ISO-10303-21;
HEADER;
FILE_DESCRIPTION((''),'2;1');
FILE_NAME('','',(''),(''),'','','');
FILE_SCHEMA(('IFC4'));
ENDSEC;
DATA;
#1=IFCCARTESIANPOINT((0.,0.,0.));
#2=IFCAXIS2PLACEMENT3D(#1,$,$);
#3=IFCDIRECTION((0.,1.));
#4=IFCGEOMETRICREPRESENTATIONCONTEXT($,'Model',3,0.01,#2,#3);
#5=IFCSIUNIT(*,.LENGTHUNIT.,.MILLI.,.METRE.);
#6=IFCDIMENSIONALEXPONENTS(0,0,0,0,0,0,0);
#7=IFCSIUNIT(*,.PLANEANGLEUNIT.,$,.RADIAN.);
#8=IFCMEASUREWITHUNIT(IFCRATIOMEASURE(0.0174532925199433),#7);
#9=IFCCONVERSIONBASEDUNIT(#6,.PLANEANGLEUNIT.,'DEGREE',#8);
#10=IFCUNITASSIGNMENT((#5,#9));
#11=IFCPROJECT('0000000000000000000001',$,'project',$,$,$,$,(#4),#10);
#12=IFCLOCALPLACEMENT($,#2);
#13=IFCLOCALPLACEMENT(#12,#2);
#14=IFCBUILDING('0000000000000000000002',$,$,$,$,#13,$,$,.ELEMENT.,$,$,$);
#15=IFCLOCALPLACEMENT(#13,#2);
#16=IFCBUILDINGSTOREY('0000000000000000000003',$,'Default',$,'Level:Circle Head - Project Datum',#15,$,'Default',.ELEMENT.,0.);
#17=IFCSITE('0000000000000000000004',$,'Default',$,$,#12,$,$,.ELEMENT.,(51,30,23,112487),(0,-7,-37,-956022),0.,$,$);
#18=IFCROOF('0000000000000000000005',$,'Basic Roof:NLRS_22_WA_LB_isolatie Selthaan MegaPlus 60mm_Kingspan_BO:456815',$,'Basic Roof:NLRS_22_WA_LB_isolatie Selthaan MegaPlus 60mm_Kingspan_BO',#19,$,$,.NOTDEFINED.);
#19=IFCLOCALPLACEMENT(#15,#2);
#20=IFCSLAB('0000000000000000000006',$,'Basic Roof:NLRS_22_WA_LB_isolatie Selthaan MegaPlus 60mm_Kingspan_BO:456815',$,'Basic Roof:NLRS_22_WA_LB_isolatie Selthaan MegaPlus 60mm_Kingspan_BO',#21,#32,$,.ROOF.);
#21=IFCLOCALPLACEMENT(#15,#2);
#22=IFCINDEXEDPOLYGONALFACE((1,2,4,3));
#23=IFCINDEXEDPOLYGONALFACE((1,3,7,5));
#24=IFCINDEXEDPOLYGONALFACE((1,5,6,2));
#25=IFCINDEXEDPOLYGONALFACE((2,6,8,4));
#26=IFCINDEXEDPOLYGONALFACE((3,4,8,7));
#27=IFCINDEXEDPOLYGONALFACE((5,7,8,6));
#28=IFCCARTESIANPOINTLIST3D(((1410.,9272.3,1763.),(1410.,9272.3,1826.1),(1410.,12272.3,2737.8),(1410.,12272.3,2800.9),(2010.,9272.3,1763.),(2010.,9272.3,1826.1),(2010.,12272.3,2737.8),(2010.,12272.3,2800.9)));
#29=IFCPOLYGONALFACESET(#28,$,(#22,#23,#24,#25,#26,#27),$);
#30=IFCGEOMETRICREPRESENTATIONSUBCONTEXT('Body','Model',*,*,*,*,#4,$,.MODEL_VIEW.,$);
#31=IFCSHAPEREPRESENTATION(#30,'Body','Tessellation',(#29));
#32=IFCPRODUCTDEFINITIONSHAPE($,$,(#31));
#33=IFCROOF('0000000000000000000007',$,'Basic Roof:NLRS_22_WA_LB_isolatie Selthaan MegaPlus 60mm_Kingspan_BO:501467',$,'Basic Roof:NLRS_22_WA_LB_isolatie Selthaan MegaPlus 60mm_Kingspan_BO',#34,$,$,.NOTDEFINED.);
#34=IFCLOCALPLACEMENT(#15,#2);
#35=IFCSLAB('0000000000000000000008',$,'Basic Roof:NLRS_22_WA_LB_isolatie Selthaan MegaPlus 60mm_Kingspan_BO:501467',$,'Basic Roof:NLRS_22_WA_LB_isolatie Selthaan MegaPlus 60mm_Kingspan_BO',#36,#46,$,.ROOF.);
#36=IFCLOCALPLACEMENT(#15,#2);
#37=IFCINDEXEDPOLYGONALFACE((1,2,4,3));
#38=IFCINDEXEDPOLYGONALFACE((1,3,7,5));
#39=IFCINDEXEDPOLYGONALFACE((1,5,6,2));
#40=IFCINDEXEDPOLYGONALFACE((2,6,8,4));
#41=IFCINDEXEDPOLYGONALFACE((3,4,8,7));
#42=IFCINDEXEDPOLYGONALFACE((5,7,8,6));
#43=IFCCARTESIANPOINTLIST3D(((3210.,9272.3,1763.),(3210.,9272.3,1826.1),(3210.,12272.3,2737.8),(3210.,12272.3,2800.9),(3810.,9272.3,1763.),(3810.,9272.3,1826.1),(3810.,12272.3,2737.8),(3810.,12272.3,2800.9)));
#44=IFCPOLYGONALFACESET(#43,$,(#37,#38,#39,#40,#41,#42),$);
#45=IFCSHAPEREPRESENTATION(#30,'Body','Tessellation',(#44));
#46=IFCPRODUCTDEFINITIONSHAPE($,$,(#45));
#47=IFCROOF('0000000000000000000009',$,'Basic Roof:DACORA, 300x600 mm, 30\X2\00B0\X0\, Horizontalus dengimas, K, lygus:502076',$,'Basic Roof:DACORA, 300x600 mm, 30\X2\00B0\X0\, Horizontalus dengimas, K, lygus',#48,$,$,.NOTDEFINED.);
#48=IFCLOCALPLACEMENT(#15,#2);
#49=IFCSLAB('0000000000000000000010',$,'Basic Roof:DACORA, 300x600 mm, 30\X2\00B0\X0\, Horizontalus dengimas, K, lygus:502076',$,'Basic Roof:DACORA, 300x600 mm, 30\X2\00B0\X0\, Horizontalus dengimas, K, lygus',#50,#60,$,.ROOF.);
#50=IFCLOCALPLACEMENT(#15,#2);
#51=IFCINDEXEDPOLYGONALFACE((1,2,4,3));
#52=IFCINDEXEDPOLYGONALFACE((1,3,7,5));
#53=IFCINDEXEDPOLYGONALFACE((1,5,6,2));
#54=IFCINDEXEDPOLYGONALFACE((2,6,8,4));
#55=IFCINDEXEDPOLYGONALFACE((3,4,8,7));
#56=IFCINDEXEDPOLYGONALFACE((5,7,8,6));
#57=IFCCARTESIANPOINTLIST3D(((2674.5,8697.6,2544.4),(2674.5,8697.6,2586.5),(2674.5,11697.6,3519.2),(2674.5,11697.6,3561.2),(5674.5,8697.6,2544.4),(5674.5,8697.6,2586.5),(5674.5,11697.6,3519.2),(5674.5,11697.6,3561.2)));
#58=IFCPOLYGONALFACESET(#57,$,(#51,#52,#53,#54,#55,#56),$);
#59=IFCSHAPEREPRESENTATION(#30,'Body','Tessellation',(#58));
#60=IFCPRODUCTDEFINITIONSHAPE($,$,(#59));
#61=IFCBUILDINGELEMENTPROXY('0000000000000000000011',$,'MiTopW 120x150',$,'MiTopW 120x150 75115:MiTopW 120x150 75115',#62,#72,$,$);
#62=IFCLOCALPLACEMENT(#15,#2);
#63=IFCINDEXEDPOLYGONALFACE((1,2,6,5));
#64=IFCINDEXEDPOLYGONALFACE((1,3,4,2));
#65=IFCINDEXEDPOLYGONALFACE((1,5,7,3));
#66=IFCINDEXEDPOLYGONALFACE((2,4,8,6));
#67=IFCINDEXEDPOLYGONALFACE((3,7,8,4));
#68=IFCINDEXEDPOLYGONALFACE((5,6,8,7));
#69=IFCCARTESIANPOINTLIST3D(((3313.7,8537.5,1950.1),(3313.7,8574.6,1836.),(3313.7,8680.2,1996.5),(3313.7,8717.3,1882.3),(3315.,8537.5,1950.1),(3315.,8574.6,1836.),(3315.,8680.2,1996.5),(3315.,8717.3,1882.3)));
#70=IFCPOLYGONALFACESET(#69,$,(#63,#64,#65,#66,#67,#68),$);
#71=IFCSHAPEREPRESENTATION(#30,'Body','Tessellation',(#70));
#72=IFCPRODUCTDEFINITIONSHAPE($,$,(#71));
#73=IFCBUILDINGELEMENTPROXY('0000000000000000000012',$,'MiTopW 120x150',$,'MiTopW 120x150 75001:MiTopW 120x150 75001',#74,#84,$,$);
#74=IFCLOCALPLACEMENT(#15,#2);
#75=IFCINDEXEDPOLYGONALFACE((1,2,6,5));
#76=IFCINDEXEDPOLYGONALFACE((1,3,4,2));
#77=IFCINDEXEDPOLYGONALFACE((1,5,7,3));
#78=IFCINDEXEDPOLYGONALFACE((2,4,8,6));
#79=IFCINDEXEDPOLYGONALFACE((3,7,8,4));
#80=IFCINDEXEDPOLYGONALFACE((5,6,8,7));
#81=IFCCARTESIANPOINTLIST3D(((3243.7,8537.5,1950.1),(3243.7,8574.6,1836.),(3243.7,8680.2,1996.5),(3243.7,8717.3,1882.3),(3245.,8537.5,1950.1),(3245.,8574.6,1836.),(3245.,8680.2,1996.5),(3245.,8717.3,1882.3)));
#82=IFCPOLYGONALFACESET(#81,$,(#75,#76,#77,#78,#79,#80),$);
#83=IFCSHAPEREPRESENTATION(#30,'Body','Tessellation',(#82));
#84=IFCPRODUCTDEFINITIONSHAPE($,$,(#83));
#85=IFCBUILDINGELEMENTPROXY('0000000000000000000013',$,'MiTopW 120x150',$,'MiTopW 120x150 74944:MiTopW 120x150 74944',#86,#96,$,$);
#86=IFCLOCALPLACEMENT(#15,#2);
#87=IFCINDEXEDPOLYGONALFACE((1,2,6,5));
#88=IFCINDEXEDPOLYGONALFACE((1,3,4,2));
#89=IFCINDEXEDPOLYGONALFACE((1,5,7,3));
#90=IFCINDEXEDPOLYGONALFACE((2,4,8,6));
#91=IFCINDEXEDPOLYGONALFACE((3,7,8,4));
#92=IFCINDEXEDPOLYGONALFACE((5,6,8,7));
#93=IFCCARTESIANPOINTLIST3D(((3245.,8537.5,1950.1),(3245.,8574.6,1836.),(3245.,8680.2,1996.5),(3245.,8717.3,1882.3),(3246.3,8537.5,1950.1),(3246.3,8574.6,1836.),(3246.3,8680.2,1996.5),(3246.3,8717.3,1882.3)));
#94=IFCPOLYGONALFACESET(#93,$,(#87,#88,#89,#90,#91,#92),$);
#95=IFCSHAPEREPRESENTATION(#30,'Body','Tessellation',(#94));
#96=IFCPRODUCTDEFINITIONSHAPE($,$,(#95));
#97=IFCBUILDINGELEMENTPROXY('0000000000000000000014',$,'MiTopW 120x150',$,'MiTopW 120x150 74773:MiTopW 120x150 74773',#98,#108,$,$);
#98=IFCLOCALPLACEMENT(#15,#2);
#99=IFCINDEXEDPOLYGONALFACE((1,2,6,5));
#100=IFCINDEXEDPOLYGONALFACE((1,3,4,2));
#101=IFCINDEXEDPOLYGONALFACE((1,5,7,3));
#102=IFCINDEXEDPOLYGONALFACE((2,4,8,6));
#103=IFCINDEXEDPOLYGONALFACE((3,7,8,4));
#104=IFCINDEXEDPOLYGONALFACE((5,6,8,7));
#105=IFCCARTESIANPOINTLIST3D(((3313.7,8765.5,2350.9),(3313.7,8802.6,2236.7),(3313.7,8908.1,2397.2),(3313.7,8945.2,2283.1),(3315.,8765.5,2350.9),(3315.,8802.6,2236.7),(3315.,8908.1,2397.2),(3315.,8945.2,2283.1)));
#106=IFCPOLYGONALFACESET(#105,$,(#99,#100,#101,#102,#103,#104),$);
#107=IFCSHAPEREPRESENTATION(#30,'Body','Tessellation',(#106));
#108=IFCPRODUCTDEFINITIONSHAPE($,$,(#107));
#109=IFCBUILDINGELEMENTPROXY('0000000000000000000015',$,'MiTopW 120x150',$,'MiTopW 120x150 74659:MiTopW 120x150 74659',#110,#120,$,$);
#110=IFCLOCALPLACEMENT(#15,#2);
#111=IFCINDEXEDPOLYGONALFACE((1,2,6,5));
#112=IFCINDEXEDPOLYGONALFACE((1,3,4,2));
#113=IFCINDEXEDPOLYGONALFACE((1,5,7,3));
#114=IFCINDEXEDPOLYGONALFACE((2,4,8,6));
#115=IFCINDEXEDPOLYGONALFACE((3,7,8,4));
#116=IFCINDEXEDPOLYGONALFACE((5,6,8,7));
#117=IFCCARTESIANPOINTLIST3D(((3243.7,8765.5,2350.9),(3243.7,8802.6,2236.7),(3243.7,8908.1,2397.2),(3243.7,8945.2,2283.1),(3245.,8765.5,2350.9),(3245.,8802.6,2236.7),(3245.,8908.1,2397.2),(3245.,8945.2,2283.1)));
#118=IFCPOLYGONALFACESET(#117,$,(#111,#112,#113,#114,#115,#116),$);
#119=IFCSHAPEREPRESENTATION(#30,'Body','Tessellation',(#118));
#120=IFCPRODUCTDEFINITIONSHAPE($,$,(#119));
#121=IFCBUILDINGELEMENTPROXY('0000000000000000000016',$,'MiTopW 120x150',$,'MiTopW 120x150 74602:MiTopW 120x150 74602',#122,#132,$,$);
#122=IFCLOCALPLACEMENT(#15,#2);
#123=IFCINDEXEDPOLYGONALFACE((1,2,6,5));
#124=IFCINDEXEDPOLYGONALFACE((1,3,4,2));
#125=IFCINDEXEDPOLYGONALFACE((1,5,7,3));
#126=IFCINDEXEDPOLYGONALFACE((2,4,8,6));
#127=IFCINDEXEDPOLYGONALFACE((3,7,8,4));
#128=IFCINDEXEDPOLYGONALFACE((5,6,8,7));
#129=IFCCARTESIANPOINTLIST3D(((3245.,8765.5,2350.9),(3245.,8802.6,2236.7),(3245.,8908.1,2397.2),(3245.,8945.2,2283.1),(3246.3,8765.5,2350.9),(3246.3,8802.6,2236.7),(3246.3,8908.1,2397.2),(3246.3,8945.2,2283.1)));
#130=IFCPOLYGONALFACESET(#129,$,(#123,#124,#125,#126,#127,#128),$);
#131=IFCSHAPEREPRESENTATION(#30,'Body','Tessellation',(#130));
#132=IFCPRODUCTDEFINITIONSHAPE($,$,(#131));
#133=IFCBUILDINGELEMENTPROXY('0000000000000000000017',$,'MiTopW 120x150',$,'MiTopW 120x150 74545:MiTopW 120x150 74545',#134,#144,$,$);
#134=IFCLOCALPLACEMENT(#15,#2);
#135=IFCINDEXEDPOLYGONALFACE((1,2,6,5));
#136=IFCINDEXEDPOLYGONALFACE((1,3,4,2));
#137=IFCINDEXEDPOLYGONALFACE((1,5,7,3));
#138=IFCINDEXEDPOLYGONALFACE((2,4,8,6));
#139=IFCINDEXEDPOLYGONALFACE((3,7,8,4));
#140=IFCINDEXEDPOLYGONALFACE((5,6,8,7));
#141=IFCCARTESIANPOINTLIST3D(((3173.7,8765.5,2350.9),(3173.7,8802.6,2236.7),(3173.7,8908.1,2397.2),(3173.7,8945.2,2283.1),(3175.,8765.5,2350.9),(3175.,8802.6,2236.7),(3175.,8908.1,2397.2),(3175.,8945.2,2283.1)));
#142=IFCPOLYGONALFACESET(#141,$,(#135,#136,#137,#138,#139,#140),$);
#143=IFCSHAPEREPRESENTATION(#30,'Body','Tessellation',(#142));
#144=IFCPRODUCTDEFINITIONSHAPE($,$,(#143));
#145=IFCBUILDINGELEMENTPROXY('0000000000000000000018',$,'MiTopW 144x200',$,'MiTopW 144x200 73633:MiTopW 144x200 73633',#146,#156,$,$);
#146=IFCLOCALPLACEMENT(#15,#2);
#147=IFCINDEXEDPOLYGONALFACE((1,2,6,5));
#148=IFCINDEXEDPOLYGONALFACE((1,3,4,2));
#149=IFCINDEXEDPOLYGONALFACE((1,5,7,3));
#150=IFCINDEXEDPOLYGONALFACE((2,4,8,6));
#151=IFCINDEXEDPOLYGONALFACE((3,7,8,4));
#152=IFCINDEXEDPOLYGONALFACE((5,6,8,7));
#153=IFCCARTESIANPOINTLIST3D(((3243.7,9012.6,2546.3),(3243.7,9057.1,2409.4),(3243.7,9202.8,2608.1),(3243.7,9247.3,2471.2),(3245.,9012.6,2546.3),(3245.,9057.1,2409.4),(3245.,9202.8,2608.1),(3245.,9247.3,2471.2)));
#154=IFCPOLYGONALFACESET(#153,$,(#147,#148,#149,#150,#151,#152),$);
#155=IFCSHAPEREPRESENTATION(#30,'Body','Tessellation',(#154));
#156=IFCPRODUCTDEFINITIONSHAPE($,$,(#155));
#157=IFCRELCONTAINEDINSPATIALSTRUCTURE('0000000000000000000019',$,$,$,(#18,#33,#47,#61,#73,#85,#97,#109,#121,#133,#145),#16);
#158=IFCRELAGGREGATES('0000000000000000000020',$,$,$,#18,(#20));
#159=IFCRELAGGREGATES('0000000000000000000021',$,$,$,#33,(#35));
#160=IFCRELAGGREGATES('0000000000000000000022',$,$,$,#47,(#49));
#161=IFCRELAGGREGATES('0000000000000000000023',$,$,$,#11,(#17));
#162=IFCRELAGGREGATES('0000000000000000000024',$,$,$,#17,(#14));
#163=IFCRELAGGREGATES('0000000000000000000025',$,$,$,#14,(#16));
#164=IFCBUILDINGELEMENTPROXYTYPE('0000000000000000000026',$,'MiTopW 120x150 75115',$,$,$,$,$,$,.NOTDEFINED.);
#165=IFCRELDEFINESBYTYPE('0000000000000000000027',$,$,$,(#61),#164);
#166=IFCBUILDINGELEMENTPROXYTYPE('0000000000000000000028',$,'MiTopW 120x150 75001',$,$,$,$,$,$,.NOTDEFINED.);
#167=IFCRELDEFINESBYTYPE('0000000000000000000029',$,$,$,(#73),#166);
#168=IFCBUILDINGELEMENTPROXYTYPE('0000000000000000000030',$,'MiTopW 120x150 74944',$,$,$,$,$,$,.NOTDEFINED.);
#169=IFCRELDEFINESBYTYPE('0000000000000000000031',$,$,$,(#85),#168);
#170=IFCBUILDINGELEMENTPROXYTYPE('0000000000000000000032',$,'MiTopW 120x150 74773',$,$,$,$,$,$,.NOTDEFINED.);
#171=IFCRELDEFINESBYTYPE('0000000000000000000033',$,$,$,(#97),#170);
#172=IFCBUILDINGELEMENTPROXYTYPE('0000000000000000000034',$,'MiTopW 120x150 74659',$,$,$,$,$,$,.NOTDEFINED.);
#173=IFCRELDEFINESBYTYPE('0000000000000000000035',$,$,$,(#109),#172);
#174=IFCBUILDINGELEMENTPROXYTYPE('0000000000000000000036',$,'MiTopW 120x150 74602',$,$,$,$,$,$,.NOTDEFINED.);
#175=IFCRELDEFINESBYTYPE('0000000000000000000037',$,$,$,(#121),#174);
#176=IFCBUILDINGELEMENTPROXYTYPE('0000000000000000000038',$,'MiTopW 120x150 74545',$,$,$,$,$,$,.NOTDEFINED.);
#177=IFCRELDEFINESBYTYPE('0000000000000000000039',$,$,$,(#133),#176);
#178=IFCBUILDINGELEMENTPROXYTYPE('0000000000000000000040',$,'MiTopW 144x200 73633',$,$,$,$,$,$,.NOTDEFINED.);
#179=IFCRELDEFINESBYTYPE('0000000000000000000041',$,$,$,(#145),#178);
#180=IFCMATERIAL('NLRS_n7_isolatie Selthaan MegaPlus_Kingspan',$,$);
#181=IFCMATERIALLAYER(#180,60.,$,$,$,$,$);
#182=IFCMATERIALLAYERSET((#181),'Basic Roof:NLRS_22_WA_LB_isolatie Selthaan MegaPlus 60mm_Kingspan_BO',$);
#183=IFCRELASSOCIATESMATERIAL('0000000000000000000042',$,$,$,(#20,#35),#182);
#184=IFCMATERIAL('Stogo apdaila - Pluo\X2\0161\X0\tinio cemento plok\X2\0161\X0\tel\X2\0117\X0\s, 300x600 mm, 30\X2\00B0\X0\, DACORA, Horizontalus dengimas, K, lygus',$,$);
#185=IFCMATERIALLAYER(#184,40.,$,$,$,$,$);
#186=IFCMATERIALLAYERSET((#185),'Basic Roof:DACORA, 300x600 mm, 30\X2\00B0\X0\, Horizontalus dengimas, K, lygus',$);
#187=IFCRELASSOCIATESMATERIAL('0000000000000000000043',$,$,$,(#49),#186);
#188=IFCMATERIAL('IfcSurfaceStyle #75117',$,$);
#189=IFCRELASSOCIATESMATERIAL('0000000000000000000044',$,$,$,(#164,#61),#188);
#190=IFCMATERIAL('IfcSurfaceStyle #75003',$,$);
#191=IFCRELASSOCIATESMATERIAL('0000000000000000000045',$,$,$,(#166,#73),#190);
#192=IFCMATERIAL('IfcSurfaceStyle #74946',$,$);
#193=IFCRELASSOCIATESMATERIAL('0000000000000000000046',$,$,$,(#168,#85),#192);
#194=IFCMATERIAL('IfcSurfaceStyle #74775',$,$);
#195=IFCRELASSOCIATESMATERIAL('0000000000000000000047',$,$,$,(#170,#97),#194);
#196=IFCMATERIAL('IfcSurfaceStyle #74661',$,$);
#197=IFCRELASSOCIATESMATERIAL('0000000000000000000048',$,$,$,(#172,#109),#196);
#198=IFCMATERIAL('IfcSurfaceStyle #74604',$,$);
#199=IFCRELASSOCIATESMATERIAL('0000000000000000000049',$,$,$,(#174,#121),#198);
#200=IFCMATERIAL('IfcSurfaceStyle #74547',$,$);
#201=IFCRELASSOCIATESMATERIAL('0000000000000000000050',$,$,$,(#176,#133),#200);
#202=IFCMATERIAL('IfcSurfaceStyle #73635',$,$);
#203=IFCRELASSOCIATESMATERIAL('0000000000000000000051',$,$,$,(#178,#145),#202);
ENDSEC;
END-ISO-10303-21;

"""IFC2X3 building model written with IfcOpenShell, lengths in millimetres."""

from ifc_helpers import new_model, entity, si_unit, converted_unit, direction, frame, frame_2d, origin, place, context, subcontext, project, spatial, polyline, rectangle, outline, extrude, source, transform, mapped, material, layer, layer_set, type_object, type_shapes, element, aggregate, save


model = new_model("IFC2X3")

# Units and contexts
model_context = context("Model", 3, precision=0.01, world=origin(), true_north=direction((0.0, 1.0)))
body_context = subcontext(model_context, "Body", "Model", "MODEL_VIEW")
ifc_project = project(units=[si_unit("LENGTHUNIT", "METRE", prefix="MILLI"), converted_unit("PLANEANGLEUNIT", "DEGREE", entity("IfcRatioMeasure", 0.0174532925199433), si_unit("PLANEANGLEUNIT", "RADIAN"), dimensions=[0, 0, 0, 0, 0, 0, 0])], contexts=[model_context])

# Site, building, storey
site_placement = place(None, origin())
site = spatial("IfcSite", under=ifc_project, at=site_placement, Name="Default", CompositionType="ELEMENT", RefLatitude=(51, 30, 23, 112487), RefLongitude=(0, -7, -37, -956022), RefElevation=0.0)
building_placement = place(site_placement, origin())
building = spatial("IfcBuilding", under=site, at=building_placement, CompositionType="ELEMENT")
storey_placement = place(building_placement, origin())
storey = spatial("IfcBuildingStorey", under=building, at=storey_placement, Name="Default", ObjectType="Level:Circle Head - Project Datum", LongName="Default", CompositionType="ELEMENT", Elevation=0.0)

# Roofs, slabs
roof_1_placement = place(storey_placement, frame((1410.0, 9272.3, 1763.0)))
roof_1 = element("IfcRoof", 1, at=roof_1_placement, inside=storey, Name="Basic Roof:NLRS_22_WA_LB_isolatie Selthaan MegaPlus 60mm_Kingspan_BO:456815", ObjectType="Basic Roof:NLRS_22_WA_LB_isolatie Selthaan MegaPlus 60mm_Kingspan_BO", ShapeType="NOTDEFINED")
ifc_material_1 = material(Name="NLRS_n7_isolatie Selthaan MegaPlus_Kingspan")
ifc_layer_1 = layer(ifc_material_1, 60.0)
ifc_layer_set_1 = layer_set([ifc_layer_1], Name="Basic Roof:NLRS_22_WA_LB_isolatie Selthaan MegaPlus 60mm_Kingspan_BO")
slab_1_placement = place(roof_1_placement, origin())
slab_1 = element("IfcSlab", 2, at=slab_1_placement, material=ifc_layer_set_1, Name="Basic Roof:NLRS_22_WA_LB_isolatie Selthaan MegaPlus 60mm_Kingspan_BO:456815", ObjectType="Basic Roof:NLRS_22_WA_LB_isolatie Selthaan MegaPlus 60mm_Kingspan_BO", PredefinedType="ROOF", context=body_context, shape_type="SweptSolid", body=[
    extrude(rectangle(XDim=600.0, YDim=3154.4, at=frame_2d((0.0, 0.0), x_axis=(-1.0, 0.0))), frame((300.0, 1500.0, 487.4), z_axis=(0.0, -0.309017, 0.951057), x_axis=(1.0, 0.0, 0.0)), (0.0, 0.309017, 0.951057), 63.1),
])
aggregate(roof_1, [slab_1])
roof_2_placement = place(storey_placement, frame((3210.0, 9272.3, 1763.0)))
roof_2 = element("IfcRoof", 3, at=roof_2_placement, inside=storey, Name="Basic Roof:NLRS_22_WA_LB_isolatie Selthaan MegaPlus 60mm_Kingspan_BO:501467", ObjectType="Basic Roof:NLRS_22_WA_LB_isolatie Selthaan MegaPlus 60mm_Kingspan_BO", ShapeType="NOTDEFINED")
slab_2_placement = place(roof_2_placement, origin())
slab_2 = element("IfcSlab", 4, at=slab_2_placement, material=ifc_layer_set_1, Name="Basic Roof:NLRS_22_WA_LB_isolatie Selthaan MegaPlus 60mm_Kingspan_BO:501467", ObjectType="Basic Roof:NLRS_22_WA_LB_isolatie Selthaan MegaPlus 60mm_Kingspan_BO", PredefinedType="ROOF", context=body_context, shape_type="SweptSolid", body=[
    extrude(rectangle(XDim=600.0, YDim=3154.4, at=frame_2d((0.0, 0.0), x_axis=(-1.0, 0.0))), frame((300.0, 1500.0, 487.4), z_axis=(0.0, -0.309017, 0.951057), x_axis=(1.0, 0.0, 0.0)), (0.0, 0.309017, 0.951057), 63.1),
])
aggregate(roof_2, [slab_2])
roof_3_placement = place(storey_placement, frame((2674.5, 8697.6, 2544.4)))
roof_3 = element("IfcRoof", 5, at=roof_3_placement, inside=storey, Name="Basic Roof:DACORA, 300x600 mm, 30°, Horizontalus dengimas, K, lygus:502076", ObjectType="Basic Roof:DACORA, 300x600 mm, 30°, Horizontalus dengimas, K, lygus", ShapeType="NOTDEFINED")
ifc_material_2 = material(Name="Stogo apdaila - Pluoštinio cemento plokštelės, 300x600 mm, 30°, DACORA, Horizontalus dengimas, K, lygus")
ifc_layer_2 = layer(ifc_material_2, 40.0)
ifc_layer_set_2 = layer_set([ifc_layer_2], Name="Basic Roof:DACORA, 300x600 mm, 30°, Horizontalus dengimas, K, lygus")
slab_3_placement = place(roof_3_placement, origin())
slab_3 = element("IfcSlab", 6, at=slab_3_placement, material=ifc_layer_set_2, Name="Basic Roof:DACORA, 300x600 mm, 30°, Horizontalus dengimas, K, lygus:502076", ObjectType="Basic Roof:DACORA, 300x600 mm, 30°, Horizontalus dengimas, K, lygus", PredefinedType="ROOF", context=body_context, shape_type="SweptSolid", body=[
    extrude(rectangle(XDim=3154.4, YDim=3000.0, at=frame_2d((0.0, 0.0), x_axis=(0.0, -1.0))), frame((1500.0, 1500.0, 487.4), z_axis=(0.0, -0.309017, 0.951057), x_axis=(1.0, 0.0, 0.0)), (0.0, 0.309017, 0.951057), 42.1),
])
aggregate(roof_3, [slab_3])

# Building element proxies
ifc_material_3 = material(Name="IfcSurfaceStyle #75117")
building_element_proxy_type_1 = type_object("IfcBuildingElementProxyType", Name="MiTopW 120x150 75115", PredefinedType="NOTDEFINED", material=ifc_material_3)
shared_shape_1 = source(origin(), body_context, "Body", "SweptSolid", [
    extrude(outline(polyline([(-75.0, -60.0), (75.0, -60.0), (75.0, 60.0), (-75.0, 60.0), (-75.0, -60.0)])), frame((75.0, 60.0, 0.0), z_axis=(0.0, 0.0, 1.0), x_axis=(-1.0, 0.0, 0.0)), (0.0, 0.0, 1.0), 1.3),
])
type_shapes(building_element_proxy_type_1, [shared_shape_1])
proxy_1_placement = place(building_placement, frame((3315.0, 8537.5, 1950.1), z_axis=(-1.0, 0.0, 0.0), x_axis=(0.0, 0.951057, 0.309017)))
element("IfcBuildingElementProxy", 7, at=proxy_1_placement, inside=storey, type_object=building_element_proxy_type_1, material=ifc_material_3, Name="MiTopW 120x150", ObjectType="MiTopW 120x150 75115:MiTopW 120x150 75115", context=body_context, shape_type="MappedRepresentation", body=[
    mapped(shared_shape_1, transform((0.0, 0.0, 0.0), scale=1.0)),
])
ifc_material_4 = material(Name="IfcSurfaceStyle #75003")
building_element_proxy_type_2 = type_object("IfcBuildingElementProxyType", Name="MiTopW 120x150 75001", PredefinedType="NOTDEFINED", material=ifc_material_4)
shared_shape_2 = source(origin(), body_context, "Body", "SweptSolid", [
    extrude(outline(polyline([(-75.0, -60.0), (75.0, -60.0), (75.0, 60.0), (-75.0, 60.0), (-75.0, -60.0)])), frame((75.0, 60.0, 0.0), z_axis=(0.0, 0.0, 1.0), x_axis=(-1.0, 0.0, 0.0)), (0.0, 0.0, 1.0), 1.3),
])
type_shapes(building_element_proxy_type_2, [shared_shape_2])
proxy_2_placement = place(building_placement, frame((3245.0, 8537.5, 1950.1), z_axis=(-1.0, 0.0, 0.0), x_axis=(0.0, 0.951057, 0.309017)))
element("IfcBuildingElementProxy", 8, at=proxy_2_placement, inside=storey, type_object=building_element_proxy_type_2, material=ifc_material_4, Name="MiTopW 120x150", ObjectType="MiTopW 120x150 75001:MiTopW 120x150 75001", context=body_context, shape_type="MappedRepresentation", body=[
    mapped(shared_shape_2, transform((0.0, 0.0, 0.0), scale=1.0)),
])
ifc_material_5 = material(Name="IfcSurfaceStyle #74946")
building_element_proxy_type_3 = type_object("IfcBuildingElementProxyType", Name="MiTopW 120x150 74944", PredefinedType="NOTDEFINED", material=ifc_material_5)
shared_shape_3 = source(origin(), body_context, "Body", "SweptSolid", [
    extrude(outline(polyline([(-75.0, -60.0), (75.0, -60.0), (75.0, 60.0), (-75.0, 60.0), (-75.0, -60.0)])), frame((75.0, 60.0, 0.0), z_axis=(0.0, 0.0, 1.0), x_axis=(-1.0, 0.0, 0.0)), (0.0, 0.0, 1.0), 1.3),
])
type_shapes(building_element_proxy_type_3, [shared_shape_3])
proxy_3_placement = place(building_placement, frame((3246.3, 8537.5, 1950.1), z_axis=(-1.0, 0.0, 0.0), x_axis=(0.0, 0.951057, 0.309017)))
element("IfcBuildingElementProxy", 9, at=proxy_3_placement, inside=storey, type_object=building_element_proxy_type_3, material=ifc_material_5, Name="MiTopW 120x150", ObjectType="MiTopW 120x150 74944:MiTopW 120x150 74944", context=body_context, shape_type="MappedRepresentation", body=[
    mapped(shared_shape_3, transform((0.0, 0.0, 0.0), scale=1.0)),
])
ifc_material_6 = material(Name="IfcSurfaceStyle #74775")
building_element_proxy_type_4 = type_object("IfcBuildingElementProxyType", Name="MiTopW 120x150 74773", PredefinedType="NOTDEFINED", material=ifc_material_6)
shared_shape_4 = source(origin(), body_context, "Body", "SweptSolid", [
    extrude(outline(polyline([(-75.0, -60.0), (75.0, -60.0), (75.0, 60.0), (-75.0, 60.0), (-75.0, -60.0)])), frame((75.0, 60.0, 0.0), z_axis=(0.0, 0.0, 1.0), x_axis=(-1.0, 0.0, 0.0)), (0.0, 0.0, 1.0), 1.3),
])
type_shapes(building_element_proxy_type_4, [shared_shape_4])
proxy_4_placement = place(building_placement, frame((3315.0, 8765.5, 2350.9), z_axis=(-1.0, 0.0, 0.0), x_axis=(0.0, 0.951057, 0.309017)))
element("IfcBuildingElementProxy", 10, at=proxy_4_placement, inside=storey, type_object=building_element_proxy_type_4, material=ifc_material_6, Name="MiTopW 120x150", ObjectType="MiTopW 120x150 74773:MiTopW 120x150 74773", context=body_context, shape_type="MappedRepresentation", body=[
    mapped(shared_shape_4, transform((0.0, 0.0, 0.0), scale=1.0)),
])
ifc_material_7 = material(Name="IfcSurfaceStyle #74661")
building_element_proxy_type_5 = type_object("IfcBuildingElementProxyType", Name="MiTopW 120x150 74659", PredefinedType="NOTDEFINED", material=ifc_material_7)
shared_shape_5 = source(origin(), body_context, "Body", "SweptSolid", [
    extrude(outline(polyline([(-75.0, -60.0), (75.0, -60.0), (75.0, 60.0), (-75.0, 60.0), (-75.0, -60.0)])), frame((75.0, 60.0, 0.0), z_axis=(0.0, 0.0, 1.0), x_axis=(-1.0, 0.0, 0.0)), (0.0, 0.0, 1.0), 1.3),
])
type_shapes(building_element_proxy_type_5, [shared_shape_5])
proxy_5_placement = place(building_placement, frame((3245.0, 8765.5, 2350.9), z_axis=(-1.0, 0.0, 0.0), x_axis=(0.0, 0.951057, 0.309017)))
element("IfcBuildingElementProxy", 11, at=proxy_5_placement, inside=storey, type_object=building_element_proxy_type_5, material=ifc_material_7, Name="MiTopW 120x150", ObjectType="MiTopW 120x150 74659:MiTopW 120x150 74659", context=body_context, shape_type="MappedRepresentation", body=[
    mapped(shared_shape_5, transform((0.0, 0.0, 0.0), scale=1.0)),
])
ifc_material_8 = material(Name="IfcSurfaceStyle #74604")
building_element_proxy_type_6 = type_object("IfcBuildingElementProxyType", Name="MiTopW 120x150 74602", PredefinedType="NOTDEFINED", material=ifc_material_8)
shared_shape_6 = source(origin(), body_context, "Body", "SweptSolid", [
    extrude(outline(polyline([(-75.0, -60.0), (75.0, -60.0), (75.0, 60.0), (-75.0, 60.0), (-75.0, -60.0)])), frame((75.0, 60.0, 0.0), z_axis=(0.0, 0.0, 1.0), x_axis=(-1.0, 0.0, 0.0)), (0.0, 0.0, 1.0), 1.3),
])
type_shapes(building_element_proxy_type_6, [shared_shape_6])
proxy_6_placement = place(building_placement, frame((3246.3, 8765.5, 2350.9), z_axis=(-1.0, 0.0, 0.0), x_axis=(0.0, 0.951057, 0.309017)))
element("IfcBuildingElementProxy", 12, at=proxy_6_placement, inside=storey, type_object=building_element_proxy_type_6, material=ifc_material_8, Name="MiTopW 120x150", ObjectType="MiTopW 120x150 74602:MiTopW 120x150 74602", context=body_context, shape_type="MappedRepresentation", body=[
    mapped(shared_shape_6, transform((0.0, 0.0, 0.0), scale=1.0)),
])
ifc_material_9 = material(Name="IfcSurfaceStyle #74547")
building_element_proxy_type_7 = type_object("IfcBuildingElementProxyType", Name="MiTopW 120x150 74545", PredefinedType="NOTDEFINED", material=ifc_material_9)
shared_shape_7 = source(origin(), body_context, "Body", "SweptSolid", [
    extrude(outline(polyline([(-75.0, -60.0), (75.0, -60.0), (75.0, 60.0), (-75.0, 60.0), (-75.0, -60.0)])), frame((75.0, 60.0, 0.0), z_axis=(0.0, 0.0, 1.0), x_axis=(-1.0, 0.0, 0.0)), (0.0, 0.0, 1.0), 1.3),
])
type_shapes(building_element_proxy_type_7, [shared_shape_7])
proxy_7_placement = place(building_placement, frame((3175.0, 8765.5, 2350.9), z_axis=(-1.0, 0.0, 0.0), x_axis=(0.0, 0.951057, 0.309017)))
element("IfcBuildingElementProxy", 13, at=proxy_7_placement, inside=storey, type_object=building_element_proxy_type_7, material=ifc_material_9, Name="MiTopW 120x150", ObjectType="MiTopW 120x150 74545:MiTopW 120x150 74545", context=body_context, shape_type="MappedRepresentation", body=[
    mapped(shared_shape_7, transform((0.0, 0.0, 0.0), scale=1.0)),
])
ifc_material_10 = material(Name="IfcSurfaceStyle #73635")
building_element_proxy_type_8 = type_object("IfcBuildingElementProxyType", Name="MiTopW 144x200 73633", PredefinedType="NOTDEFINED", material=ifc_material_10)
shared_shape_8 = source(origin(), body_context, "Body", "SweptSolid", [
    extrude(outline(polyline([(-100.0, -72.0), (100.0, -72.0), (100.0, 72.0), (-100.0, 72.0), (-100.0, -72.0)])), frame((100.0, 72.0, 0.0), z_axis=(0.0, 0.0, 1.0), x_axis=(-1.0, 0.0, 0.0)), (0.0, 0.0, 1.0), 1.3),
])
type_shapes(building_element_proxy_type_8, [shared_shape_8])
proxy_8_placement = place(building_placement, frame((3245.0, 9012.6, 2546.3), z_axis=(-1.0, 0.0, 0.0), x_axis=(0.0, 0.951057, 0.309017)))
element("IfcBuildingElementProxy", 14, at=proxy_8_placement, inside=storey, type_object=building_element_proxy_type_8, material=ifc_material_10, Name="MiTopW 144x200", ObjectType="MiTopW 144x200 73633:MiTopW 144x200 73633", context=body_context, shape_type="MappedRepresentation", body=[
    mapped(shared_shape_8, transform((0.0, 0.0, 0.0), scale=1.0)),
])

save(model, "model.ifc")
